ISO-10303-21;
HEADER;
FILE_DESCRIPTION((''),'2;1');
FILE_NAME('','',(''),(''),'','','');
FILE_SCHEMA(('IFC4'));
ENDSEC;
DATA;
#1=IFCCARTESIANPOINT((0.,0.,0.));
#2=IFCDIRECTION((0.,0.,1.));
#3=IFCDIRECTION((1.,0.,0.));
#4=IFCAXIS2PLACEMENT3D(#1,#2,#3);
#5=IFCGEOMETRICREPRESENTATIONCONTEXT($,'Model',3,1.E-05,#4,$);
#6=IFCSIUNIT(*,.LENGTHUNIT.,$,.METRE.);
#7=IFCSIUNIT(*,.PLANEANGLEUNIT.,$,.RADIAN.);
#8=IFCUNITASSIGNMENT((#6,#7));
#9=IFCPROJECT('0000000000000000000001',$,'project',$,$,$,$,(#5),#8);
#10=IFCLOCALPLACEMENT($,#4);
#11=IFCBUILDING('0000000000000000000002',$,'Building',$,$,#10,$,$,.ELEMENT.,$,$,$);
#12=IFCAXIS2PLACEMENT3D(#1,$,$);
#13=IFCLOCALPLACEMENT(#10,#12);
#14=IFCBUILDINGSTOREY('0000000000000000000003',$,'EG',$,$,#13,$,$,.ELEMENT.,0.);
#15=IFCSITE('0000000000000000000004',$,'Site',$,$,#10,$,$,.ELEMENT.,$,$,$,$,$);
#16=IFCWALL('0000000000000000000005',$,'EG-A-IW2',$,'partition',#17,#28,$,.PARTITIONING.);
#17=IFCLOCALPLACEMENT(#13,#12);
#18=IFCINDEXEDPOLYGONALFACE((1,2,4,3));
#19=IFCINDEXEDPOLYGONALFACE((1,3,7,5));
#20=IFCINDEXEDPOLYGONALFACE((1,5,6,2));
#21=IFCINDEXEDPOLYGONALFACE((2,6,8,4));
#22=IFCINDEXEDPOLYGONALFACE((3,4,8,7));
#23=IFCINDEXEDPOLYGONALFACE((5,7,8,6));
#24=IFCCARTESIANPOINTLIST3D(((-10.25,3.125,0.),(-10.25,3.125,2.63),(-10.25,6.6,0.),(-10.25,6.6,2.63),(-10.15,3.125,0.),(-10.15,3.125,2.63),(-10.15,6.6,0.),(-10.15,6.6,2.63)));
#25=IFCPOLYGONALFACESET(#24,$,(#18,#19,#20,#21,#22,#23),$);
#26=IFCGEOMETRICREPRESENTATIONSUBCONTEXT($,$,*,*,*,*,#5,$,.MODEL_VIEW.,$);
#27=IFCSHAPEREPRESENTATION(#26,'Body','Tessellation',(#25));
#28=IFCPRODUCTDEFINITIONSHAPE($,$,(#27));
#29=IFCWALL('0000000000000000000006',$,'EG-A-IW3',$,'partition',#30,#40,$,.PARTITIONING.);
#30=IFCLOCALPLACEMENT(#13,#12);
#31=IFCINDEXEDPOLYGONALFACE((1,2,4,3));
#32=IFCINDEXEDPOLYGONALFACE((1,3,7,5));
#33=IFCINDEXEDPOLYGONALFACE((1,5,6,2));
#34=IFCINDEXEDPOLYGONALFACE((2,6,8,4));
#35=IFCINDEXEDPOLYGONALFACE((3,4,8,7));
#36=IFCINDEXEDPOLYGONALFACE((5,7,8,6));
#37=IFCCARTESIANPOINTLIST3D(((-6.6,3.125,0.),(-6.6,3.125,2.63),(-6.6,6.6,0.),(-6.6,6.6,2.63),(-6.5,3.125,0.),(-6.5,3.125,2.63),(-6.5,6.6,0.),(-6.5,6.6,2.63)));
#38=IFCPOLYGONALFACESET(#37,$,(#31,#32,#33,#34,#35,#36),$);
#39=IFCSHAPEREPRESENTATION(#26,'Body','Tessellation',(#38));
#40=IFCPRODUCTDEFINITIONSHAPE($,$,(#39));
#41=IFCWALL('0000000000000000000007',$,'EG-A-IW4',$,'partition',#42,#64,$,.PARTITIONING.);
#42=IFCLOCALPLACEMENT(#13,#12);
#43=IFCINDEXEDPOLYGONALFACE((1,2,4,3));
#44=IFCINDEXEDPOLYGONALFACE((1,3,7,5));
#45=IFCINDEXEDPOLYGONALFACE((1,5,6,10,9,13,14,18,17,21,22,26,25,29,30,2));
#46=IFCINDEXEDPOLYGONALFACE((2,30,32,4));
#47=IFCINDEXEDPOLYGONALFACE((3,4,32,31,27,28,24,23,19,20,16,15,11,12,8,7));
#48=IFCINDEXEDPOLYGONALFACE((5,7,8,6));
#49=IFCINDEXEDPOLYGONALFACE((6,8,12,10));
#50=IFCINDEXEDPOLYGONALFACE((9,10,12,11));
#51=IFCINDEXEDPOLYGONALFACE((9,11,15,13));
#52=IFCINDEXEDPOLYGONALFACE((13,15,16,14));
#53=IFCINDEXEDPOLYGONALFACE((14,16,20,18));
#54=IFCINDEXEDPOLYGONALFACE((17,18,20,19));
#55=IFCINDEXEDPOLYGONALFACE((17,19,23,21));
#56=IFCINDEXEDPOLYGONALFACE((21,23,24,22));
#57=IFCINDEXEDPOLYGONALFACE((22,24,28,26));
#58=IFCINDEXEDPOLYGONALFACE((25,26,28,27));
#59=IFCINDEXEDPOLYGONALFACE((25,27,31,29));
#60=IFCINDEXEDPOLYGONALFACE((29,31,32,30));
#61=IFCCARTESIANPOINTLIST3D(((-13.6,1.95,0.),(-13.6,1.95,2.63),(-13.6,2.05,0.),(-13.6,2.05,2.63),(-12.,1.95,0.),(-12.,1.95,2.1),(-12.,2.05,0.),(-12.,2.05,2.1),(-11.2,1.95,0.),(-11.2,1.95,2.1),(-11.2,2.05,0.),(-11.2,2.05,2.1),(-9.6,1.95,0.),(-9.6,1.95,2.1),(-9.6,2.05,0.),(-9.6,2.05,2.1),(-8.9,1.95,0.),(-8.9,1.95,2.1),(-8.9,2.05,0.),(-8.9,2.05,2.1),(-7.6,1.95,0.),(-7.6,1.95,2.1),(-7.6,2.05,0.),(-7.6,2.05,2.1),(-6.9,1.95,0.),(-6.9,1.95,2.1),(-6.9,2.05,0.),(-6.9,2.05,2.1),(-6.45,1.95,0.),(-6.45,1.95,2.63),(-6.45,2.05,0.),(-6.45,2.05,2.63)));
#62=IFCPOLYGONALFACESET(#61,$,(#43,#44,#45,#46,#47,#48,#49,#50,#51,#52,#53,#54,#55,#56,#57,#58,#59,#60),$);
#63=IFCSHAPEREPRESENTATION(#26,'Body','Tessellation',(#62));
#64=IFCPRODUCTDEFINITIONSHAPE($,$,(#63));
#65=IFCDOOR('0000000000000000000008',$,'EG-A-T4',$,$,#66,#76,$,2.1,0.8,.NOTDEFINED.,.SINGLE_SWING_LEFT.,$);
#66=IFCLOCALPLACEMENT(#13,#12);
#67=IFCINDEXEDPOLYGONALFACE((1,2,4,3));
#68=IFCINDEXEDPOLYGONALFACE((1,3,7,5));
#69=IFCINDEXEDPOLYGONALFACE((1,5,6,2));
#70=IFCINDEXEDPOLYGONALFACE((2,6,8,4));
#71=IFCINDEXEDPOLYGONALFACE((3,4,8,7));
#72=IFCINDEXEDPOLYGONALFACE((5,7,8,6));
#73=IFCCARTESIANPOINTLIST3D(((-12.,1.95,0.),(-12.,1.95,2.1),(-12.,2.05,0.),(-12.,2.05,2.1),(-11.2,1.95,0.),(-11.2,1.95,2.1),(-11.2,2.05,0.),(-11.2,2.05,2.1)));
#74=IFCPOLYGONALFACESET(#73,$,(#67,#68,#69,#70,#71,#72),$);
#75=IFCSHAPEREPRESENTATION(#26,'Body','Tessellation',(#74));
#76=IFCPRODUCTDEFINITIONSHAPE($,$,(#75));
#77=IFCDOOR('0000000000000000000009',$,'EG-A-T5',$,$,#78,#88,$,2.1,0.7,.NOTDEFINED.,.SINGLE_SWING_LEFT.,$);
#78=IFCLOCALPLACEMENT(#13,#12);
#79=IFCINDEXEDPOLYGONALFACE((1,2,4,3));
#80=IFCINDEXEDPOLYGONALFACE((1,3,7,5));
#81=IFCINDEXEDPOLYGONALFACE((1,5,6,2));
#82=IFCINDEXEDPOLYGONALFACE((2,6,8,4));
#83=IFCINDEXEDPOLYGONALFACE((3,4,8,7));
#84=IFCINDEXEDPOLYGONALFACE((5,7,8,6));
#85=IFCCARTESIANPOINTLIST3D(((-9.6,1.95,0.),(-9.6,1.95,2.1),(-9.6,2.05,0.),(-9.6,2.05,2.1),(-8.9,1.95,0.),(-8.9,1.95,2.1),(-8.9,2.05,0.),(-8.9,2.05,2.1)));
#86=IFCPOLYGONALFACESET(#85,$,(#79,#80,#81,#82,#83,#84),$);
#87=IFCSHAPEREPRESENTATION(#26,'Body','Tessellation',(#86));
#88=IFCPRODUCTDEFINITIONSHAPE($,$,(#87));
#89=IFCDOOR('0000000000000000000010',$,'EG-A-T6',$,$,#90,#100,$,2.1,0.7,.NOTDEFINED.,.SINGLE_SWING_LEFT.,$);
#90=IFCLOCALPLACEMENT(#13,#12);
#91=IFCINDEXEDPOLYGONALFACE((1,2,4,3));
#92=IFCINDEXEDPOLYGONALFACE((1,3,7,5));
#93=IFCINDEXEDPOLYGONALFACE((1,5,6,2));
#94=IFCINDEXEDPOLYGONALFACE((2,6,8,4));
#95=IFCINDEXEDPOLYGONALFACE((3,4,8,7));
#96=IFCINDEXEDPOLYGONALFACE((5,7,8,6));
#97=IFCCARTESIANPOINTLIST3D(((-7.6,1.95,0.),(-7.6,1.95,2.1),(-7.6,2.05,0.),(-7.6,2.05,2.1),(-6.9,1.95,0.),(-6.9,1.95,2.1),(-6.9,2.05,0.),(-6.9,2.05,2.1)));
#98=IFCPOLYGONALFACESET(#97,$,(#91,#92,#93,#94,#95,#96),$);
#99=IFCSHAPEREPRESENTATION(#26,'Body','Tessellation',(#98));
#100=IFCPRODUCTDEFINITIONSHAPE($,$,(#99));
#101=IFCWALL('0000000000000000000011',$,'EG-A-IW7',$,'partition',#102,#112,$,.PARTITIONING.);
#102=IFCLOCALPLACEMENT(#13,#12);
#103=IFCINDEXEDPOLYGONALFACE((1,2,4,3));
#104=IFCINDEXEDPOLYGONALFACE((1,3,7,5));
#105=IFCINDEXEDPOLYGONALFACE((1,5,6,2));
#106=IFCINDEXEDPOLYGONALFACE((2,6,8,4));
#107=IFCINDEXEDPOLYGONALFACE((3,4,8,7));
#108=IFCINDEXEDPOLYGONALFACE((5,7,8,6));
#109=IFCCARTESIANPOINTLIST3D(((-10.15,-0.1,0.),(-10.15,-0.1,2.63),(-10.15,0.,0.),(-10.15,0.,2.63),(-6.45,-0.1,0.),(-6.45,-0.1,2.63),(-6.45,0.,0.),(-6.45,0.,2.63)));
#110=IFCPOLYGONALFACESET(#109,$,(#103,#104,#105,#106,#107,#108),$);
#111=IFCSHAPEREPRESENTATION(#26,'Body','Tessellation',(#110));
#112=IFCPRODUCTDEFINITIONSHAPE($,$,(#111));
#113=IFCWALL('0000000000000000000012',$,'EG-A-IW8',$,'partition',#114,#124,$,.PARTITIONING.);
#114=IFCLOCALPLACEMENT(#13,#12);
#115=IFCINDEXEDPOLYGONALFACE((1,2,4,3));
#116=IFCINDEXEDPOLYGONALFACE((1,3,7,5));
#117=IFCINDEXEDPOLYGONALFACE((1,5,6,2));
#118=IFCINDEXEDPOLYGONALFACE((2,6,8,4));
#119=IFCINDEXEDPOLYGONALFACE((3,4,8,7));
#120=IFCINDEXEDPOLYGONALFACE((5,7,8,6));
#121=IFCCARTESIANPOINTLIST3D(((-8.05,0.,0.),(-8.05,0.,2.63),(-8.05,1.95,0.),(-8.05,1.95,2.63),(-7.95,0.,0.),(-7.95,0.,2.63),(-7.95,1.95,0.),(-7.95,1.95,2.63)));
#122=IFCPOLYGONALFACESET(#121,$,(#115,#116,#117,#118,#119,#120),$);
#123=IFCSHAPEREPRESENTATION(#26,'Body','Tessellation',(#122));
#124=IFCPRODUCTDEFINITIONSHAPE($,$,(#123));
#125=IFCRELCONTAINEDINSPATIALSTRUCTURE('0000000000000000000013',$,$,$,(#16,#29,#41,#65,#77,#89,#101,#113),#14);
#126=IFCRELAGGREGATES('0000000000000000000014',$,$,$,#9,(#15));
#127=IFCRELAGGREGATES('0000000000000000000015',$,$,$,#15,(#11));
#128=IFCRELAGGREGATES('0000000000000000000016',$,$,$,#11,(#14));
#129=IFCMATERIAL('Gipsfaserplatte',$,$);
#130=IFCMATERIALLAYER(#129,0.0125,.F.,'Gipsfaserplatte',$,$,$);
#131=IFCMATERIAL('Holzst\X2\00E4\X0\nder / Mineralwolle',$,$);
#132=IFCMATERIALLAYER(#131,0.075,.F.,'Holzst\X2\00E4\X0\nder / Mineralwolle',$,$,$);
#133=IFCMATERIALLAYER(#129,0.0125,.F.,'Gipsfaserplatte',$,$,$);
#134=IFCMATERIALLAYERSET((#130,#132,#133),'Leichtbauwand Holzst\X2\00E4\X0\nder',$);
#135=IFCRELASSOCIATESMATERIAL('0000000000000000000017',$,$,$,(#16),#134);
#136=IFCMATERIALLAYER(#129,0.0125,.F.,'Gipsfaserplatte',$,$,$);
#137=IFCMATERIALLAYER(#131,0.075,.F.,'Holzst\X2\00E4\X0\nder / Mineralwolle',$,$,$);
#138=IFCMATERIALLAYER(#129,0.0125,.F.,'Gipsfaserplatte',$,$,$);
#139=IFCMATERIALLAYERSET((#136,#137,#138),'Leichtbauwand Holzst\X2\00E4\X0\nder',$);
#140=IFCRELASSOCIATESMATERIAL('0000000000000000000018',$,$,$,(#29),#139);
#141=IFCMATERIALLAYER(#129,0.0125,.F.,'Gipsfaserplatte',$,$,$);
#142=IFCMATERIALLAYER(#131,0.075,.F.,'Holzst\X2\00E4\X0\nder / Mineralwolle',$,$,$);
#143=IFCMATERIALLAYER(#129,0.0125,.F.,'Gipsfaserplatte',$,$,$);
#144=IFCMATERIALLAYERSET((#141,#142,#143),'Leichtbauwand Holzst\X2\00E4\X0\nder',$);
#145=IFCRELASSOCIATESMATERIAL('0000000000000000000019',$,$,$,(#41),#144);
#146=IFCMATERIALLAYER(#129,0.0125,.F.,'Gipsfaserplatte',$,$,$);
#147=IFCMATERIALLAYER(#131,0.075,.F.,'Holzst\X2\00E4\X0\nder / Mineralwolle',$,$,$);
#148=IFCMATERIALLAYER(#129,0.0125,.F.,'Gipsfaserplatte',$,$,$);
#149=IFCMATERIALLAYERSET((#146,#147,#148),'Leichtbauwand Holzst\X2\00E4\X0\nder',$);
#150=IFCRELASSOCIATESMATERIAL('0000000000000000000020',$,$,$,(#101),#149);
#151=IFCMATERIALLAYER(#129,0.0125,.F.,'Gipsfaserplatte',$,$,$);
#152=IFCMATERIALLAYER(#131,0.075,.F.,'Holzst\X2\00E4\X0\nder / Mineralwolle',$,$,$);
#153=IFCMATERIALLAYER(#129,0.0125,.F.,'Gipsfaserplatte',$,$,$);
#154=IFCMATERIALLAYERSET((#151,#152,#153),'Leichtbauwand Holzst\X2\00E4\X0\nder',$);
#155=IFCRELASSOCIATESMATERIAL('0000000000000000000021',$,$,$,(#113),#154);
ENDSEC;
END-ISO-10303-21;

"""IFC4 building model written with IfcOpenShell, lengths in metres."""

from ifc_helpers import new_model, si_unit, frame, frame_2d, origin, origin_with_axes, place, context, subcontext, project, spatial, rectangle, extrude, material, layer, layer_set, element, fill, save


model = new_model("IFC4")

# Units and contexts
model_context = context("Model", 3, precision=1e-05, world=origin_with_axes())
sub_context = subcontext(model_context, None, None, "MODEL_VIEW")
ifc_project = project(units=[si_unit("LENGTHUNIT", "METRE"), si_unit("PLANEANGLEUNIT", "RADIAN")], contexts=[model_context])

# Site, building, storey
placement = place(None, origin_with_axes())
site = spatial("IfcSite", under=ifc_project, at=placement, Name="Site", CompositionType="ELEMENT")
building = spatial("IfcBuilding", under=site, at=placement, Name="Building", CompositionType="ELEMENT")
storey_placement = place(placement, origin())
storey = spatial("IfcBuildingStorey", under=building, at=storey_placement, Name="EG", CompositionType="ELEMENT", Elevation=0.0)

# Shared definitions
ifc_material_1 = material(Name="Gipsfaserplatte")

# Walls
ifc_layer_1 = layer(ifc_material_1, 0.0125, ventilated=False, Name="Gipsfaserplatte")
ifc_material_2 = material(Name="Holzständer / Mineralwolle")
ifc_layer_2 = layer(ifc_material_2, 0.075, ventilated=False, Name="Holzständer / Mineralwolle")
ifc_layer_3 = layer(ifc_material_1, 0.0125, ventilated=False, Name="Gipsfaserplatte")
ifc_layer_set_1 = layer_set([ifc_layer_1, ifc_layer_2, ifc_layer_3], Name="Leichtbauwand Holzständer")
wall_1_placement = place(storey_placement, frame((-10.2, 3.125, 0.0), z_axis=(0.0, 0.0, 1.0), x_axis=(0.0, 1.0, 0.0)))
element("IfcWall", 1, at=wall_1_placement, inside=storey, material=ifc_layer_set_1, Name="EG-A-IW2", ObjectType="partition", PredefinedType="PARTITIONING", context=sub_context, shape_type="SweptSolid", body=[
    extrude(rectangle(XDim=3.475, YDim=0.1, at=frame_2d((1.7375, 0.0))), origin(), (0.0, 0.0, 1.0), 2.63),
])
ifc_layer_4 = layer(ifc_material_1, 0.0125, ventilated=False, Name="Gipsfaserplatte")
ifc_layer_5 = layer(ifc_material_2, 0.075, ventilated=False, Name="Holzständer / Mineralwolle")
ifc_layer_6 = layer(ifc_material_1, 0.0125, ventilated=False, Name="Gipsfaserplatte")
ifc_layer_set_2 = layer_set([ifc_layer_4, ifc_layer_5, ifc_layer_6], Name="Leichtbauwand Holzständer")
wall_2_placement = place(storey_placement, frame((-6.55, 3.125, 0.0), z_axis=(0.0, 0.0, 1.0), x_axis=(0.0, 1.0, 0.0)))
element("IfcWall", 2, at=wall_2_placement, inside=storey, material=ifc_layer_set_2, Name="EG-A-IW3", ObjectType="partition", PredefinedType="PARTITIONING", context=sub_context, shape_type="SweptSolid", body=[
    extrude(rectangle(XDim=3.475, YDim=0.1, at=frame_2d((1.7375, 0.0))), origin(), (0.0, 0.0, 1.0), 2.63),
])

# Wall, openings, doors
ifc_layer_7 = layer(ifc_material_1, 0.0125, ventilated=False, Name="Gipsfaserplatte")
ifc_layer_8 = layer(ifc_material_2, 0.075, ventilated=False, Name="Holzständer / Mineralwolle")
ifc_layer_9 = layer(ifc_material_1, 0.0125, ventilated=False, Name="Gipsfaserplatte")
ifc_layer_set_3 = layer_set([ifc_layer_7, ifc_layer_8, ifc_layer_9], Name="Leichtbauwand Holzständer")
wall_3_placement = place(storey_placement, frame((-13.6, 2.0, 0.0), z_axis=(0.0, 0.0, 1.0), x_axis=(1.0, 0.0, 0.0)))
wall_3 = element("IfcWall", 3, at=wall_3_placement, inside=storey, material=ifc_layer_set_3, Name="EG-A-IW4", ObjectType="partition", PredefinedType="PARTITIONING", context=sub_context, shape_type="SweptSolid", body=[
    extrude(rectangle(XDim=7.15, YDim=0.1, at=frame_2d((3.575, 0.0))), origin(), (0.0, 0.0, 1.0), 2.63),
])
opening_1_placement = place(wall_3_placement, frame((2.0, 0.1, 0.0), z_axis=(0.0, -1.0, 0.0), x_axis=(1.0, 0.0, 0.0)))
opening_1 = element("IfcOpeningElement", 4, at=opening_1_placement, cuts=wall_3, PredefinedType="OPENING", context=sub_context, shape_type="SweptSolid", body=[
    extrude(rectangle(XDim=0.8, YDim=2.1, at=frame_2d((0.0, 1.05))), origin(), (0.0, 0.0, 1.0), 0.2),
])
opening_2_placement = place(wall_3_placement, frame((4.35, 0.1, 0.0), z_axis=(0.0, -1.0, 0.0), x_axis=(1.0, 0.0, 0.0)))
opening_2 = element("IfcOpeningElement", 5, at=opening_2_placement, cuts=wall_3, PredefinedType="OPENING", context=sub_context, shape_type="SweptSolid", body=[
    extrude(rectangle(XDim=0.7, YDim=2.1, at=frame_2d((0.0, 1.05))), origin(), (0.0, 0.0, 1.0), 0.2),
])
opening_3_placement = place(wall_3_placement, frame((6.35, 0.1, 0.0), z_axis=(0.0, -1.0, 0.0), x_axis=(1.0, 0.0, 0.0)))
opening_3 = element("IfcOpeningElement", 6, at=opening_3_placement, cuts=wall_3, PredefinedType="OPENING", context=sub_context, shape_type="SweptSolid", body=[
    extrude(rectangle(XDim=0.7, YDim=2.1, at=frame_2d((0.0, 1.05))), origin(), (0.0, 0.0, 1.0), 0.2),
])
door_1_placement = place(wall_3_placement, frame((2.0, 0.05, 0.0), z_axis=(0.0, -1.0, 0.0), x_axis=(1.0, 0.0, 0.0)))
door_1 = element("IfcDoor", 7, at=door_1_placement, inside=storey, Name="EG-A-T4", OperationType="SINGLE_SWING_LEFT", OverallHeight=2.1, OverallWidth=0.8, PredefinedType="NOTDEFINED", context=sub_context, shape_type="SweptSolid", body=[
    extrude(rectangle(XDim=0.8, YDim=2.1, at=frame_2d((0.0, 1.05))), origin(), (0.0, 0.0, 1.0), 0.1),
])
fill(opening_1, door_1)
door_2_placement = place(wall_3_placement, frame((4.35, 0.05, 0.0), z_axis=(0.0, -1.0, 0.0), x_axis=(1.0, 0.0, 0.0)))
door_2 = element("IfcDoor", 8, at=door_2_placement, inside=storey, Name="EG-A-T5", OperationType="SINGLE_SWING_LEFT", OverallHeight=2.1, OverallWidth=0.7, PredefinedType="NOTDEFINED", context=sub_context, shape_type="SweptSolid", body=[
    extrude(rectangle(XDim=0.7, YDim=2.1, at=frame_2d((0.0, 1.05))), origin(), (0.0, 0.0, 1.0), 0.1),
])
fill(opening_2, door_2)
door_3_placement = place(wall_3_placement, frame((6.35, 0.05, 0.0), z_axis=(0.0, -1.0, 0.0), x_axis=(1.0, 0.0, 0.0)))
door_3 = element("IfcDoor", 9, at=door_3_placement, inside=storey, Name="EG-A-T6", OperationType="SINGLE_SWING_LEFT", OverallHeight=2.1, OverallWidth=0.7, PredefinedType="NOTDEFINED", context=sub_context, shape_type="SweptSolid", body=[
    extrude(rectangle(XDim=0.7, YDim=2.1, at=frame_2d((0.0, 1.05))), origin(), (0.0, 0.0, 1.0), 0.1),
])
fill(opening_3, door_3)

# Walls
ifc_layer_10 = layer(ifc_material_1, 0.0125, ventilated=False, Name="Gipsfaserplatte")
ifc_layer_11 = layer(ifc_material_2, 0.075, ventilated=False, Name="Holzständer / Mineralwolle")
ifc_layer_12 = layer(ifc_material_1, 0.0125, ventilated=False, Name="Gipsfaserplatte")
ifc_layer_set_4 = layer_set([ifc_layer_10, ifc_layer_11, ifc_layer_12], Name="Leichtbauwand Holzständer")
wall_4_placement = place(storey_placement, frame((-10.15, -0.05, 0.0), z_axis=(0.0, 0.0, 1.0), x_axis=(1.0, 0.0, 0.0)))
element("IfcWall", 10, at=wall_4_placement, inside=storey, material=ifc_layer_set_4, Name="EG-A-IW7", ObjectType="partition", PredefinedType="PARTITIONING", context=sub_context, shape_type="SweptSolid", body=[
    extrude(rectangle(XDim=3.7, YDim=0.1, at=frame_2d((1.85, 0.0))), origin(), (0.0, 0.0, 1.0), 2.63),
])
ifc_layer_13 = layer(ifc_material_1, 0.0125, ventilated=False, Name="Gipsfaserplatte")
ifc_layer_14 = layer(ifc_material_2, 0.075, ventilated=False, Name="Holzständer / Mineralwolle")
ifc_layer_15 = layer(ifc_material_1, 0.0125, ventilated=False, Name="Gipsfaserplatte")
ifc_layer_set_5 = layer_set([ifc_layer_13, ifc_layer_14, ifc_layer_15], Name="Leichtbauwand Holzständer")
wall_5_placement = place(storey_placement, frame((-8.0, 0.0, 0.0), z_axis=(0.0, 0.0, 1.0), x_axis=(0.0, 1.0, 0.0)))
element("IfcWall", 11, at=wall_5_placement, inside=storey, material=ifc_layer_set_5, Name="EG-A-IW8", ObjectType="partition", PredefinedType="PARTITIONING", context=sub_context, shape_type="SweptSolid", body=[
    extrude(rectangle(XDim=1.95, YDim=0.1, at=frame_2d((0.975, 0.0))), origin(), (0.0, 0.0, 1.0), 2.63),
])

save(model, "model.ifc")
